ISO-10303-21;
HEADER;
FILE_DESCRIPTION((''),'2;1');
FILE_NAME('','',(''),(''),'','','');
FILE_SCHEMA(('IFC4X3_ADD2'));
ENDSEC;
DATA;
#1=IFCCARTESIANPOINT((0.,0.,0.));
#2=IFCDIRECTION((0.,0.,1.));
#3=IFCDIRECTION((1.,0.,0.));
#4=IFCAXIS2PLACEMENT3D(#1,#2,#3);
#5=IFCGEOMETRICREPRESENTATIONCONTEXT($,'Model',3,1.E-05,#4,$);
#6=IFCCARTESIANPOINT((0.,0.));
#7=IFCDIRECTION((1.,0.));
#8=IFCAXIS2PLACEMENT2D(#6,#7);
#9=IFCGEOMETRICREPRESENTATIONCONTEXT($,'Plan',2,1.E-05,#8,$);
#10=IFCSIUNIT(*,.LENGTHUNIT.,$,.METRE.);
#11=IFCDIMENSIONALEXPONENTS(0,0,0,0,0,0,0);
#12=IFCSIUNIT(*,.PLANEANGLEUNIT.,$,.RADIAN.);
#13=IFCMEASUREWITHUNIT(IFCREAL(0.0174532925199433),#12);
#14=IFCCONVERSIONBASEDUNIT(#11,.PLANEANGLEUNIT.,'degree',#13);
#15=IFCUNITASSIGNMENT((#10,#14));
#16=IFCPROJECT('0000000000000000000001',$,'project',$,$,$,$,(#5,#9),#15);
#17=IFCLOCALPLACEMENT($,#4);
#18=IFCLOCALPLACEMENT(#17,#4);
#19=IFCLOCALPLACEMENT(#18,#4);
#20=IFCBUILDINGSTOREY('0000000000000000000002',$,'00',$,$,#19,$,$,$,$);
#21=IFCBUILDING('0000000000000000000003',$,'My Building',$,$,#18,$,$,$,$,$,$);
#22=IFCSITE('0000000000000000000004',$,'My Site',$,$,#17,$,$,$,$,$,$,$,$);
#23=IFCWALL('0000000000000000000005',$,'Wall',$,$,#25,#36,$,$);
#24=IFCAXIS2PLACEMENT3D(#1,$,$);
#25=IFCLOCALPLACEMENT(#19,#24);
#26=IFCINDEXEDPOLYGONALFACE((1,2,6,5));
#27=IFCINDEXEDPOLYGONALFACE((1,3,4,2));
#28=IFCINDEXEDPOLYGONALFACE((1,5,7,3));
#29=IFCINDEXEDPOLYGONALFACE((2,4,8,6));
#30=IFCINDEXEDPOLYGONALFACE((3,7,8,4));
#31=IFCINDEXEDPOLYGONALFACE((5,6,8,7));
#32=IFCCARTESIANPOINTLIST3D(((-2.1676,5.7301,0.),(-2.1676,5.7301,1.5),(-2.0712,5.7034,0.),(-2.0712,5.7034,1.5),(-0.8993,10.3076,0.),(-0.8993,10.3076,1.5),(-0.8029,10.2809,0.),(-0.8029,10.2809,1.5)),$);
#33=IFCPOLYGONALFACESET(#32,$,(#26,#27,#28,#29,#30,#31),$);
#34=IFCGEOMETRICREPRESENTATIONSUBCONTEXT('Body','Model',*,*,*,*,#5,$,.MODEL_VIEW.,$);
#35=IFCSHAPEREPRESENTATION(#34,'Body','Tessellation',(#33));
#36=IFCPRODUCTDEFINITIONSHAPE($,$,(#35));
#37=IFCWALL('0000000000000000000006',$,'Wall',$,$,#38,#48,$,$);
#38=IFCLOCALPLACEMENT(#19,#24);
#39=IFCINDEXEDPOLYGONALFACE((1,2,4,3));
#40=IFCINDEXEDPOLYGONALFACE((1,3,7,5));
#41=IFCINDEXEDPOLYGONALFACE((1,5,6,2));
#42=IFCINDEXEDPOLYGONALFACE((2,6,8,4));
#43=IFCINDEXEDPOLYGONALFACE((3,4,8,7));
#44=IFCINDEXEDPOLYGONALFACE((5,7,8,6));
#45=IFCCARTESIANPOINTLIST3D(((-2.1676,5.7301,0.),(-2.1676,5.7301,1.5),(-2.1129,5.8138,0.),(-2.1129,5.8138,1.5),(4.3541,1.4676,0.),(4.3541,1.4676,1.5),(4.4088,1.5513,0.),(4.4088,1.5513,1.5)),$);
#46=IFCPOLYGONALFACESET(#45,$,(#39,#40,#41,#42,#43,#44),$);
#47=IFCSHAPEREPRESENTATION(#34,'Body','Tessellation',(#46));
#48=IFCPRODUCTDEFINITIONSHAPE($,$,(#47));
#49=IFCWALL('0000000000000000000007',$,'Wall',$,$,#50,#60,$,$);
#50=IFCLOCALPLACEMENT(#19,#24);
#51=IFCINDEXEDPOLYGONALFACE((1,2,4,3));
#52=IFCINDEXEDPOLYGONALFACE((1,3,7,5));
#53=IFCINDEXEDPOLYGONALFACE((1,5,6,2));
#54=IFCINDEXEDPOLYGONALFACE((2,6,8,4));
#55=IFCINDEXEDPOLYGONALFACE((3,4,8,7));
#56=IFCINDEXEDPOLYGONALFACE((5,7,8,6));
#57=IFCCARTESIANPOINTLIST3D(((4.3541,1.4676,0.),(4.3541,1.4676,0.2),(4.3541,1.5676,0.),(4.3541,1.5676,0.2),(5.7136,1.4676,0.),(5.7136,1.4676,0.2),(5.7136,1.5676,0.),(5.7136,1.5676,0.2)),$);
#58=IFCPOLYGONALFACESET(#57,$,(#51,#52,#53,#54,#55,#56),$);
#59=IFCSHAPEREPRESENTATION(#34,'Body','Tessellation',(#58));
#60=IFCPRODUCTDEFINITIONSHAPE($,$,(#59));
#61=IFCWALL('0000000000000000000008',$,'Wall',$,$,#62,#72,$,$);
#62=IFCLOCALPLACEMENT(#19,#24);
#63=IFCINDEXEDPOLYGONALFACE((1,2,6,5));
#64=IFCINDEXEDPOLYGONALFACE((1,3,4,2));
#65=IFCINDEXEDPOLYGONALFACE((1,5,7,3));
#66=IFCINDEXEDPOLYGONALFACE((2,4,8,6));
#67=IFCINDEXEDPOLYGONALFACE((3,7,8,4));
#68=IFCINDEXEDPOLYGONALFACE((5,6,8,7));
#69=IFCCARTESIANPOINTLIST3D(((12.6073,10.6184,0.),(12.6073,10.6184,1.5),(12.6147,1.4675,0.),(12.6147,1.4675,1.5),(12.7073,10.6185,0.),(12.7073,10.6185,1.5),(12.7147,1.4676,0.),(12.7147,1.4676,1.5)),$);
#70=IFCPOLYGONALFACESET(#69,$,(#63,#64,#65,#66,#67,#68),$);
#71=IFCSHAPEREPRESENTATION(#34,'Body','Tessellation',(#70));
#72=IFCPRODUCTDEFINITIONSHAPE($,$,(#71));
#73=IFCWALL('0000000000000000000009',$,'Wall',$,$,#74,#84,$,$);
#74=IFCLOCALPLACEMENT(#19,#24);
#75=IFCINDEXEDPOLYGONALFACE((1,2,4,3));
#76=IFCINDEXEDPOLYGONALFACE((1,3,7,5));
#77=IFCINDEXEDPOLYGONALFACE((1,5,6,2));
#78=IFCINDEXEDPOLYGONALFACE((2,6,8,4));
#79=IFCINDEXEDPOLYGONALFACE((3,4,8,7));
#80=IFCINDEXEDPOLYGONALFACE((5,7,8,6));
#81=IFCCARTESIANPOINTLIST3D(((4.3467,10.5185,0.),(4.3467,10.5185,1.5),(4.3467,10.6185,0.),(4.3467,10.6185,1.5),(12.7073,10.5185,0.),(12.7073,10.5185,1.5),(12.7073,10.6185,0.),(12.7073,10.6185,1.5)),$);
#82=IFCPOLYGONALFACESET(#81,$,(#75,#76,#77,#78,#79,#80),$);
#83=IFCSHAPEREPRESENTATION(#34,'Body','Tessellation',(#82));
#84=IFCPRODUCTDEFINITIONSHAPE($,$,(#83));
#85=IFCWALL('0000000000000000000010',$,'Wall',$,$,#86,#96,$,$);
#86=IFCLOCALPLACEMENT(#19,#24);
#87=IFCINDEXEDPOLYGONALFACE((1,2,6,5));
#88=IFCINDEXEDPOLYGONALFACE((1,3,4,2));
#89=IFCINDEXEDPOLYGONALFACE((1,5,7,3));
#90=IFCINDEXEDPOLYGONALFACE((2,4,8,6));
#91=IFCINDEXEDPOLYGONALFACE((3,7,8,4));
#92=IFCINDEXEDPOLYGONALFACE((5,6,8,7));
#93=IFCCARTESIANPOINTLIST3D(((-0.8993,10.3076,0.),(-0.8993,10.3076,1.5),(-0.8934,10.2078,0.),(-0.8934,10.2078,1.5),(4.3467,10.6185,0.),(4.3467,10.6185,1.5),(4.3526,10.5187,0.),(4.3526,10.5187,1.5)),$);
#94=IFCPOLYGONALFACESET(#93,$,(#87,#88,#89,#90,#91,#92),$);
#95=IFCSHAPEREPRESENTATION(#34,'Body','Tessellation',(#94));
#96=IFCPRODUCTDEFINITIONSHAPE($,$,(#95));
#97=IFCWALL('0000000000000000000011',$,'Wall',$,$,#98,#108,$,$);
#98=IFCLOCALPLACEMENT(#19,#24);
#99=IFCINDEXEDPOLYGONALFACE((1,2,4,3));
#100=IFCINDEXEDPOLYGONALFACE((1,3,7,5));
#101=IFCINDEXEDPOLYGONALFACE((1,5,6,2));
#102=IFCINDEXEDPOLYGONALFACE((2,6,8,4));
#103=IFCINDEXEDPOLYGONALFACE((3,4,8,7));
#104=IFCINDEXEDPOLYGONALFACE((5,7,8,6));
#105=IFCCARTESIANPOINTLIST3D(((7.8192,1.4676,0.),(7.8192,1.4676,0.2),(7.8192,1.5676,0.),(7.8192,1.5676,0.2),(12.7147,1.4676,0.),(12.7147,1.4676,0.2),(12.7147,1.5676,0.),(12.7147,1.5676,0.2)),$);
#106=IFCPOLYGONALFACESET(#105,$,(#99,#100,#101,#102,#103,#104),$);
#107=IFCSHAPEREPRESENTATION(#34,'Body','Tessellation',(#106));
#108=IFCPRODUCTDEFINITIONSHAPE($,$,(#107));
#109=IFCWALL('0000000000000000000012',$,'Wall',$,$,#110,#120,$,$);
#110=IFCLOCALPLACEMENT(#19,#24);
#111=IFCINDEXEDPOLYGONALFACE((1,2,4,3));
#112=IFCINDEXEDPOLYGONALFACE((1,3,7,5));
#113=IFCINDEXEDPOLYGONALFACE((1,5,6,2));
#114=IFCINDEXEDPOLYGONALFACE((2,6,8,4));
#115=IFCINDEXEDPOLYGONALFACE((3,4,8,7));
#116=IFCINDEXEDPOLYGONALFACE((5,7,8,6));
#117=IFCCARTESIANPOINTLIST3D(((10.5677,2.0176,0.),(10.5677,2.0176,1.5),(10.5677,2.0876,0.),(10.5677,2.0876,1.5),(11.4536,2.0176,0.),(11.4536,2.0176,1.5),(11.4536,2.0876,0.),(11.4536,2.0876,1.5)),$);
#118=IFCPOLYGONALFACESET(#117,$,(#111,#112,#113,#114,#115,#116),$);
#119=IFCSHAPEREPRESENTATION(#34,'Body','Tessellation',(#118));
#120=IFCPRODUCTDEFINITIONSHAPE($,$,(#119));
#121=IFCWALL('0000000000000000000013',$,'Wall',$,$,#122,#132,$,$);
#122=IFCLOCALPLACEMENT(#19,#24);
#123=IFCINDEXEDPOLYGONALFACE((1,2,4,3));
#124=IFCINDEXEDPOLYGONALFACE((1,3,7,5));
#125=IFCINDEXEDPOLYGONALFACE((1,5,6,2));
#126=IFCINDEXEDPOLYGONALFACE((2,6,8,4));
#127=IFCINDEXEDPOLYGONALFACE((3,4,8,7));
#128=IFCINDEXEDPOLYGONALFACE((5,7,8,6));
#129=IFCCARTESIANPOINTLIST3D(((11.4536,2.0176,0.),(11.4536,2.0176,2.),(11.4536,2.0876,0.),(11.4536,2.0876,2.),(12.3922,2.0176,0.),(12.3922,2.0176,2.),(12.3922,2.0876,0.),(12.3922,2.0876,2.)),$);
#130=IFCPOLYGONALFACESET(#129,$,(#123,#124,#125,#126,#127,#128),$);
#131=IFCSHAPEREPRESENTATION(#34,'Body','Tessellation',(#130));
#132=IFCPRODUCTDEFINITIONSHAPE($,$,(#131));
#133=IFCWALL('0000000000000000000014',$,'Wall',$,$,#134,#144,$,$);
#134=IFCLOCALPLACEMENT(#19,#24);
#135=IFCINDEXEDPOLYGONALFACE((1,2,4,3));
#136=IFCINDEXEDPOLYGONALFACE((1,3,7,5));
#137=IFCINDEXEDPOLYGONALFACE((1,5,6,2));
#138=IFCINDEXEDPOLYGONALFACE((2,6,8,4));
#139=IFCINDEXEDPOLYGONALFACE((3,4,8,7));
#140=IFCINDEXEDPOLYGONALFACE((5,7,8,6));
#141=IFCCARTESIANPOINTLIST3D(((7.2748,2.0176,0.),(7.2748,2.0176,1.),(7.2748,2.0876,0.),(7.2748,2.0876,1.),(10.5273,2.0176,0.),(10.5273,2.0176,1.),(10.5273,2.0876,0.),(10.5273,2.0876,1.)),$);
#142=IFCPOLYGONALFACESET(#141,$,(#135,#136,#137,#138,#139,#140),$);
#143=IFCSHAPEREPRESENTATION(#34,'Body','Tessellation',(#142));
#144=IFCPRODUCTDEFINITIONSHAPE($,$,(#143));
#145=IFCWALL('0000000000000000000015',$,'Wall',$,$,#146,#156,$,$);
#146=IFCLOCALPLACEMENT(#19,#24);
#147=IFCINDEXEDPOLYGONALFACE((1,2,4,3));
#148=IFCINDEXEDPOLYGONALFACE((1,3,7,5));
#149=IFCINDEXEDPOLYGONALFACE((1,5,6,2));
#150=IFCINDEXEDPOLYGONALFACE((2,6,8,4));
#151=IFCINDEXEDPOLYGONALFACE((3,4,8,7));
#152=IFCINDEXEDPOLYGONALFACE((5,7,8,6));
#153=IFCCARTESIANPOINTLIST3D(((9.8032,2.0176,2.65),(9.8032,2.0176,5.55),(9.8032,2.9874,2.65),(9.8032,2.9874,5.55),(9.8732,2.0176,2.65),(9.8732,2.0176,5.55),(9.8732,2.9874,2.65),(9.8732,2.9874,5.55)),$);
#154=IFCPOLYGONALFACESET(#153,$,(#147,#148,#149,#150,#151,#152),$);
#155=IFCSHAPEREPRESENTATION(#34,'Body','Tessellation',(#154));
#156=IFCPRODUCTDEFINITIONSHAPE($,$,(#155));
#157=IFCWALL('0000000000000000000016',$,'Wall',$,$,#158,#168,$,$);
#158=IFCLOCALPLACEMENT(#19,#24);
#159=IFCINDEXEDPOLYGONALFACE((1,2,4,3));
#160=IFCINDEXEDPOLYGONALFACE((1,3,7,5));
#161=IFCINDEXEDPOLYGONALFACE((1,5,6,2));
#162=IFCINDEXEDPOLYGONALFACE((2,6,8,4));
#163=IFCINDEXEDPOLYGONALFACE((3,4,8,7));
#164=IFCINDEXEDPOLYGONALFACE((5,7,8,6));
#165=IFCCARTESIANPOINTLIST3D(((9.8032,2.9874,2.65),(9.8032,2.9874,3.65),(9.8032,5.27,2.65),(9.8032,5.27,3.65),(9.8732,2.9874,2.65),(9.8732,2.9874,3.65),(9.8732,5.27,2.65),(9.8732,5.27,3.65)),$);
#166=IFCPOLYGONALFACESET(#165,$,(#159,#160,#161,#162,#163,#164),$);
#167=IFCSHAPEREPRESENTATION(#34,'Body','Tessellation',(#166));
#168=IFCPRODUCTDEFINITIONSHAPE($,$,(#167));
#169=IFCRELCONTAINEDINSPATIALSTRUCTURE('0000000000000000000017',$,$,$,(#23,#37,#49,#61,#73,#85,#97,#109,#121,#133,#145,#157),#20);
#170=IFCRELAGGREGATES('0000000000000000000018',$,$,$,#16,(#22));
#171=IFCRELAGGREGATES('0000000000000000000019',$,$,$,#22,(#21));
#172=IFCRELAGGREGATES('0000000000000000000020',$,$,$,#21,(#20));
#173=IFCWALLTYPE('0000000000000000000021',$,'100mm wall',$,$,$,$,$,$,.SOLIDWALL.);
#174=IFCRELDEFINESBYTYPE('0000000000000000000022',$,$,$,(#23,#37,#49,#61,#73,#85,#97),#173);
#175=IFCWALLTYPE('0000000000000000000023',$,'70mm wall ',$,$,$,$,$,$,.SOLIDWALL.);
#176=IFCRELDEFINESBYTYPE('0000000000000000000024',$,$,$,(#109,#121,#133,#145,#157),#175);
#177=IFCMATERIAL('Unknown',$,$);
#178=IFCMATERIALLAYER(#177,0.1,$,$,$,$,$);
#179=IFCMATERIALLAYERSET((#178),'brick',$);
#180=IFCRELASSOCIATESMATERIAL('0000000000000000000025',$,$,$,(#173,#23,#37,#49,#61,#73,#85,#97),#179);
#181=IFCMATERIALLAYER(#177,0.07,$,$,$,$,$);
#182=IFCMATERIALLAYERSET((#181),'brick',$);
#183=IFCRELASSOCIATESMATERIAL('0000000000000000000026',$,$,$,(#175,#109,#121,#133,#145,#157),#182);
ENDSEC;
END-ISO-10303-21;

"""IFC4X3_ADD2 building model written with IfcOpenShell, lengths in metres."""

from ifc_helpers import new_model, entity, si_unit, converted_unit, frame, origin_with_axes, origin_2d_with_axis, place, context, subcontext, project, spatial, line, indexed_curve, outline, extrude, material, layer, layer_set, layer_usage, type_object, element, save


model = new_model("IFC4X3_ADD2")

# Units and contexts
model_context = context("Model", 3, precision=1e-05, world=origin_with_axes())
plan_context = context("Plan", 2, precision=1e-05, world=origin_2d_with_axis())
body_context = subcontext(model_context, "Body", "Model", "MODEL_VIEW")
ifc_project = project(units=[si_unit("LENGTHUNIT", "METRE"), converted_unit("PLANEANGLEUNIT", "degree", entity("IfcReal", 0.0174532925199433), si_unit("PLANEANGLEUNIT", "RADIAN"), dimensions=[0, 0, 0, 0, 0, 0, 0])], contexts=[model_context, plan_context])

# Site, building, storey
site_placement = place(None, origin_with_axes())
site = spatial("IfcSite", under=ifc_project, at=site_placement, Name="My Site")
building_placement = place(site_placement, origin_with_axes())
building = spatial("IfcBuilding", under=site, at=building_placement, Name="My Building")
storey_placement = place(building_placement, origin_with_axes())
storey = spatial("IfcBuildingStorey", under=building, at=storey_placement, Name="00")

# Walls
ifc_material = material(Name="Unknown")
ifc_layer_1 = layer(ifc_material, 0.1)
ifc_layer_set_1 = layer_set([ifc_layer_1], Name="brick")
ifc_layer_usage_1 = layer_usage(ifc_layer_set_1, "AXIS2", "POSITIVE", 0.0)
wall_type_1 = type_object("IfcWallType", Name="100mm wall", PredefinedType="SOLIDWALL", material=ifc_layer_set_1)
wall_1_placement = place(storey_placement, frame((-0.8993, 10.3076, 0.0), z_axis=(0.0, 0.0, 1.0), x_axis=(-0.267012, -0.963693, 0.0)))
element("IfcWall", 1, at=wall_1_placement, inside=storey, type_object=wall_type_1, material=ifc_layer_usage_1, Name="Wall", context=body_context, shape_type="SweptSolid", body=[
    extrude(outline(indexed_curve([(0.0, 0.0), (0.0, 0.1), (4.75, 0.1), (4.75, 0.0)], segments=[line(1, 2, 3, 4, 1)])), origin_with_axes(), (0.0, 0.0, 1.0), 1.5),
])
ifc_layer_usage_2 = layer_usage(ifc_layer_set_1, "AXIS2", "POSITIVE", 0.0)
wall_2_placement = place(storey_placement, frame((-2.1676, 5.7301, 0.0), z_axis=(0.0, 0.0, 1.0), x_axis=(0.837068, -0.547098, 0.0)))
element("IfcWall", 2, at=wall_2_placement, inside=storey, type_object=wall_type_1, material=ifc_layer_usage_2, Name="Wall", context=body_context, shape_type="SweptSolid", body=[
    extrude(outline(indexed_curve([(0.0, 0.0), (0.0, 0.1), (7.7911, 0.1), (7.7911, 0.0)], segments=[line(1, 2, 3, 4, 1)])), origin_with_axes(), (0.0, 0.0, 1.0), 1.5),
])
ifc_layer_usage_3 = layer_usage(ifc_layer_set_1, "AXIS2", "POSITIVE", 0.0)
wall_3_placement = place(storey_placement, frame((4.3541, 1.4676, 0.0), z_axis=(0.0, 0.0, 1.0), x_axis=(1.0, 0.0, 0.0)))
element("IfcWall", 3, at=wall_3_placement, inside=storey, type_object=wall_type_1, material=ifc_layer_usage_3, Name="Wall", context=body_context, shape_type="SweptSolid", body=[
    extrude(outline(indexed_curve([(0.0, 0.0), (0.0, 0.1), (1.3596, 0.1), (1.3596, 0.0)], segments=[line(1, 2, 3, 4, 1)])), origin_with_axes(), (0.0, 0.0, 1.0), 0.2),
])
ifc_layer_usage_4 = layer_usage(ifc_layer_set_1, "AXIS2", "POSITIVE", 0.0)
wall_4_placement = place(storey_placement, frame((12.7147, 1.4676, 0.0), z_axis=(0.0, 0.0, 1.0), x_axis=(-0.000805, 1.0, 0.0)))
element("IfcWall", 4, at=wall_4_placement, inside=storey, type_object=wall_type_1, material=ifc_layer_usage_4, Name="Wall", context=body_context, shape_type="SweptSolid", body=[
    extrude(outline(indexed_curve([(0.0, 0.0), (0.0, 0.1), (9.1509, 0.1), (9.1509, 0.0)], segments=[line(1, 2, 3, 4, 1)])), origin_with_axes(), (0.0, 0.0, 1.0), 1.5),
])
ifc_layer_usage_5 = layer_usage(ifc_layer_set_1, "AXIS2", "POSITIVE", 0.0)
wall_5_placement = place(storey_placement, frame((12.7073, 10.6185, 0.0), z_axis=(0.0, 0.0, 1.0), x_axis=(-1.0, 0.0, 0.0)))
element("IfcWall", 5, at=wall_5_placement, inside=storey, type_object=wall_type_1, material=ifc_layer_usage_5, Name="Wall", context=body_context, shape_type="SweptSolid", body=[
    extrude(outline(indexed_curve([(0.0, 0.0), (0.0, 0.1), (8.3606, 0.1), (8.3606, 0.0)], segments=[line(1, 2, 3, 4, 1)])), origin_with_axes(), (0.0, 0.0, 1.0), 1.5),
])
ifc_layer_usage_6 = layer_usage(ifc_layer_set_1, "AXIS2", "POSITIVE", 0.0)
wall_6_placement = place(storey_placement, frame((4.3467, 10.6185, 0.0), z_axis=(0.0, 0.0, 1.0), x_axis=(-0.998249, -0.059157, 0.0)))
element("IfcWall", 6, at=wall_6_placement, inside=storey, type_object=wall_type_1, material=ifc_layer_usage_6, Name="Wall", context=body_context, shape_type="SweptSolid", body=[
    extrude(outline(indexed_curve([(0.0, 0.0), (0.0, 0.1), (5.2552, 0.1), (5.2552, 0.0)], segments=[line(1, 2, 3, 4, 1)])), origin_with_axes(), (0.0, 0.0, 1.0), 1.5),
])
ifc_layer_usage_7 = layer_usage(ifc_layer_set_1, "AXIS2", "POSITIVE", 0.0)
wall_7_placement = place(storey_placement, frame((7.8192, 1.4676, 0.0), z_axis=(0.0, 0.0, 1.0), x_axis=(1.0, 0.0, 0.0)))
element("IfcWall", 7, at=wall_7_placement, inside=storey, type_object=wall_type_1, material=ifc_layer_usage_7, Name="Wall", context=body_context, shape_type="SweptSolid", body=[
    extrude(outline(indexed_curve([(0.0, 0.0), (0.0, 0.1), (4.8954, 0.1), (4.8954, 0.0)], segments=[line(1, 2, 3, 4, 1)])), origin_with_axes(), (0.0, 0.0, 1.0), 0.2),
])
ifc_layer_2 = layer(ifc_material, 0.07)
ifc_layer_set_2 = layer_set([ifc_layer_2], Name="brick")
ifc_layer_usage_8 = layer_usage(ifc_layer_set_2, "AXIS2", "POSITIVE", 0.0)
wall_type_2 = type_object("IfcWallType", Name="70mm wall ", PredefinedType="SOLIDWALL", material=ifc_layer_set_2)
wall_8_placement = place(storey_placement, frame((10.5677, 2.0176, 0.0), z_axis=(0.0, 0.0, 1.0), x_axis=(1.0, 0.0, 0.0)))
element("IfcWall", 8, at=wall_8_placement, inside=storey, type_object=wall_type_2, material=ifc_layer_usage_8, Name="Wall", context=body_context, shape_type="SweptSolid", body=[
    extrude(outline(indexed_curve([(0.0, 0.0), (0.0, 0.07), (0.8859, 0.07), (0.8859, 0.0)], segments=[line(1, 2, 3, 4, 1)])), origin_with_axes(), (0.0, 0.0, 1.0), 1.5),
])
ifc_layer_usage_9 = layer_usage(ifc_layer_set_2, "AXIS2", "POSITIVE", 0.0)
wall_9_placement = place(storey_placement, frame((11.4536, 2.0176, 0.0), z_axis=(0.0, 0.0, 1.0), x_axis=(1.0, 0.0, 0.0)))
element("IfcWall", 9, at=wall_9_placement, inside=storey, type_object=wall_type_2, material=ifc_layer_usage_9, Name="Wall", context=body_context, shape_type="SweptSolid", body=[
    extrude(outline(indexed_curve([(0.0, 0.0), (0.0, 0.07), (0.9386, 0.07), (0.9386, 0.0)], segments=[line(1, 2, 3, 4, 1)])), origin_with_axes(), (0.0, 0.0, 1.0), 2.0),
])
ifc_layer_usage_10 = layer_usage(ifc_layer_set_2, "AXIS2", "POSITIVE", 0.0)
wall_10_placement = place(storey_placement, frame((7.2748, 2.0176, 0.0), z_axis=(0.0, 0.0, 1.0), x_axis=(1.0, 0.0, 0.0)))
element("IfcWall", 10, at=wall_10_placement, inside=storey, type_object=wall_type_2, material=ifc_layer_usage_10, Name="Wall", context=body_context, shape_type="SweptSolid", body=[
    extrude(outline(indexed_curve([(0.0, 0.0), (0.0, 0.07), (3.2525, 0.07), (3.2525, 0.0)], segments=[line(1, 2, 3, 4, 1)])), origin_with_axes(), (0.0, 0.0, 1.0), 1.0),
])
ifc_layer_usage_11 = layer_usage(ifc_layer_set_2, "AXIS2", "POSITIVE", 0.0)
wall_11_placement = place(storey_placement, frame((9.8732, 2.0176, 2.65), z_axis=(0.0, 0.0, 1.0), x_axis=(0.0, 1.0, 0.0)))
element("IfcWall", 11, at=wall_11_placement, inside=storey, type_object=wall_type_2, material=ifc_layer_usage_11, Name="Wall", context=body_context, shape_type="SweptSolid", body=[
    extrude(outline(indexed_curve([(0.0, 0.0), (0.0, 0.07), (0.9698, 0.07), (0.9698, 0.0)], segments=[line(1, 2, 3, 4, 1)])), origin_with_axes(), (0.0, 0.0, 1.0), 2.9),
])
ifc_layer_usage_12 = layer_usage(ifc_layer_set_2, "AXIS2", "POSITIVE", 0.0)
wall_12_placement = place(storey_placement, frame((9.8732, 2.9874, 2.65), z_axis=(0.0, 0.0, 1.0), x_axis=(0.0, 1.0, 0.0)))
element("IfcWall", 12, at=wall_12_placement, inside=storey, type_object=wall_type_2, material=ifc_layer_usage_12, Name="Wall", context=body_context, shape_type="SweptSolid", body=[
    extrude(outline(indexed_curve([(0.0, 0.0), (0.0, 0.07), (2.2826, 0.07), (2.2826, 0.0)], segments=[line(1, 2, 3, 4, 1)])), origin_with_axes(), (0.0, 0.0, 1.0), 1.0),
])

save(model, "model.ifc")
